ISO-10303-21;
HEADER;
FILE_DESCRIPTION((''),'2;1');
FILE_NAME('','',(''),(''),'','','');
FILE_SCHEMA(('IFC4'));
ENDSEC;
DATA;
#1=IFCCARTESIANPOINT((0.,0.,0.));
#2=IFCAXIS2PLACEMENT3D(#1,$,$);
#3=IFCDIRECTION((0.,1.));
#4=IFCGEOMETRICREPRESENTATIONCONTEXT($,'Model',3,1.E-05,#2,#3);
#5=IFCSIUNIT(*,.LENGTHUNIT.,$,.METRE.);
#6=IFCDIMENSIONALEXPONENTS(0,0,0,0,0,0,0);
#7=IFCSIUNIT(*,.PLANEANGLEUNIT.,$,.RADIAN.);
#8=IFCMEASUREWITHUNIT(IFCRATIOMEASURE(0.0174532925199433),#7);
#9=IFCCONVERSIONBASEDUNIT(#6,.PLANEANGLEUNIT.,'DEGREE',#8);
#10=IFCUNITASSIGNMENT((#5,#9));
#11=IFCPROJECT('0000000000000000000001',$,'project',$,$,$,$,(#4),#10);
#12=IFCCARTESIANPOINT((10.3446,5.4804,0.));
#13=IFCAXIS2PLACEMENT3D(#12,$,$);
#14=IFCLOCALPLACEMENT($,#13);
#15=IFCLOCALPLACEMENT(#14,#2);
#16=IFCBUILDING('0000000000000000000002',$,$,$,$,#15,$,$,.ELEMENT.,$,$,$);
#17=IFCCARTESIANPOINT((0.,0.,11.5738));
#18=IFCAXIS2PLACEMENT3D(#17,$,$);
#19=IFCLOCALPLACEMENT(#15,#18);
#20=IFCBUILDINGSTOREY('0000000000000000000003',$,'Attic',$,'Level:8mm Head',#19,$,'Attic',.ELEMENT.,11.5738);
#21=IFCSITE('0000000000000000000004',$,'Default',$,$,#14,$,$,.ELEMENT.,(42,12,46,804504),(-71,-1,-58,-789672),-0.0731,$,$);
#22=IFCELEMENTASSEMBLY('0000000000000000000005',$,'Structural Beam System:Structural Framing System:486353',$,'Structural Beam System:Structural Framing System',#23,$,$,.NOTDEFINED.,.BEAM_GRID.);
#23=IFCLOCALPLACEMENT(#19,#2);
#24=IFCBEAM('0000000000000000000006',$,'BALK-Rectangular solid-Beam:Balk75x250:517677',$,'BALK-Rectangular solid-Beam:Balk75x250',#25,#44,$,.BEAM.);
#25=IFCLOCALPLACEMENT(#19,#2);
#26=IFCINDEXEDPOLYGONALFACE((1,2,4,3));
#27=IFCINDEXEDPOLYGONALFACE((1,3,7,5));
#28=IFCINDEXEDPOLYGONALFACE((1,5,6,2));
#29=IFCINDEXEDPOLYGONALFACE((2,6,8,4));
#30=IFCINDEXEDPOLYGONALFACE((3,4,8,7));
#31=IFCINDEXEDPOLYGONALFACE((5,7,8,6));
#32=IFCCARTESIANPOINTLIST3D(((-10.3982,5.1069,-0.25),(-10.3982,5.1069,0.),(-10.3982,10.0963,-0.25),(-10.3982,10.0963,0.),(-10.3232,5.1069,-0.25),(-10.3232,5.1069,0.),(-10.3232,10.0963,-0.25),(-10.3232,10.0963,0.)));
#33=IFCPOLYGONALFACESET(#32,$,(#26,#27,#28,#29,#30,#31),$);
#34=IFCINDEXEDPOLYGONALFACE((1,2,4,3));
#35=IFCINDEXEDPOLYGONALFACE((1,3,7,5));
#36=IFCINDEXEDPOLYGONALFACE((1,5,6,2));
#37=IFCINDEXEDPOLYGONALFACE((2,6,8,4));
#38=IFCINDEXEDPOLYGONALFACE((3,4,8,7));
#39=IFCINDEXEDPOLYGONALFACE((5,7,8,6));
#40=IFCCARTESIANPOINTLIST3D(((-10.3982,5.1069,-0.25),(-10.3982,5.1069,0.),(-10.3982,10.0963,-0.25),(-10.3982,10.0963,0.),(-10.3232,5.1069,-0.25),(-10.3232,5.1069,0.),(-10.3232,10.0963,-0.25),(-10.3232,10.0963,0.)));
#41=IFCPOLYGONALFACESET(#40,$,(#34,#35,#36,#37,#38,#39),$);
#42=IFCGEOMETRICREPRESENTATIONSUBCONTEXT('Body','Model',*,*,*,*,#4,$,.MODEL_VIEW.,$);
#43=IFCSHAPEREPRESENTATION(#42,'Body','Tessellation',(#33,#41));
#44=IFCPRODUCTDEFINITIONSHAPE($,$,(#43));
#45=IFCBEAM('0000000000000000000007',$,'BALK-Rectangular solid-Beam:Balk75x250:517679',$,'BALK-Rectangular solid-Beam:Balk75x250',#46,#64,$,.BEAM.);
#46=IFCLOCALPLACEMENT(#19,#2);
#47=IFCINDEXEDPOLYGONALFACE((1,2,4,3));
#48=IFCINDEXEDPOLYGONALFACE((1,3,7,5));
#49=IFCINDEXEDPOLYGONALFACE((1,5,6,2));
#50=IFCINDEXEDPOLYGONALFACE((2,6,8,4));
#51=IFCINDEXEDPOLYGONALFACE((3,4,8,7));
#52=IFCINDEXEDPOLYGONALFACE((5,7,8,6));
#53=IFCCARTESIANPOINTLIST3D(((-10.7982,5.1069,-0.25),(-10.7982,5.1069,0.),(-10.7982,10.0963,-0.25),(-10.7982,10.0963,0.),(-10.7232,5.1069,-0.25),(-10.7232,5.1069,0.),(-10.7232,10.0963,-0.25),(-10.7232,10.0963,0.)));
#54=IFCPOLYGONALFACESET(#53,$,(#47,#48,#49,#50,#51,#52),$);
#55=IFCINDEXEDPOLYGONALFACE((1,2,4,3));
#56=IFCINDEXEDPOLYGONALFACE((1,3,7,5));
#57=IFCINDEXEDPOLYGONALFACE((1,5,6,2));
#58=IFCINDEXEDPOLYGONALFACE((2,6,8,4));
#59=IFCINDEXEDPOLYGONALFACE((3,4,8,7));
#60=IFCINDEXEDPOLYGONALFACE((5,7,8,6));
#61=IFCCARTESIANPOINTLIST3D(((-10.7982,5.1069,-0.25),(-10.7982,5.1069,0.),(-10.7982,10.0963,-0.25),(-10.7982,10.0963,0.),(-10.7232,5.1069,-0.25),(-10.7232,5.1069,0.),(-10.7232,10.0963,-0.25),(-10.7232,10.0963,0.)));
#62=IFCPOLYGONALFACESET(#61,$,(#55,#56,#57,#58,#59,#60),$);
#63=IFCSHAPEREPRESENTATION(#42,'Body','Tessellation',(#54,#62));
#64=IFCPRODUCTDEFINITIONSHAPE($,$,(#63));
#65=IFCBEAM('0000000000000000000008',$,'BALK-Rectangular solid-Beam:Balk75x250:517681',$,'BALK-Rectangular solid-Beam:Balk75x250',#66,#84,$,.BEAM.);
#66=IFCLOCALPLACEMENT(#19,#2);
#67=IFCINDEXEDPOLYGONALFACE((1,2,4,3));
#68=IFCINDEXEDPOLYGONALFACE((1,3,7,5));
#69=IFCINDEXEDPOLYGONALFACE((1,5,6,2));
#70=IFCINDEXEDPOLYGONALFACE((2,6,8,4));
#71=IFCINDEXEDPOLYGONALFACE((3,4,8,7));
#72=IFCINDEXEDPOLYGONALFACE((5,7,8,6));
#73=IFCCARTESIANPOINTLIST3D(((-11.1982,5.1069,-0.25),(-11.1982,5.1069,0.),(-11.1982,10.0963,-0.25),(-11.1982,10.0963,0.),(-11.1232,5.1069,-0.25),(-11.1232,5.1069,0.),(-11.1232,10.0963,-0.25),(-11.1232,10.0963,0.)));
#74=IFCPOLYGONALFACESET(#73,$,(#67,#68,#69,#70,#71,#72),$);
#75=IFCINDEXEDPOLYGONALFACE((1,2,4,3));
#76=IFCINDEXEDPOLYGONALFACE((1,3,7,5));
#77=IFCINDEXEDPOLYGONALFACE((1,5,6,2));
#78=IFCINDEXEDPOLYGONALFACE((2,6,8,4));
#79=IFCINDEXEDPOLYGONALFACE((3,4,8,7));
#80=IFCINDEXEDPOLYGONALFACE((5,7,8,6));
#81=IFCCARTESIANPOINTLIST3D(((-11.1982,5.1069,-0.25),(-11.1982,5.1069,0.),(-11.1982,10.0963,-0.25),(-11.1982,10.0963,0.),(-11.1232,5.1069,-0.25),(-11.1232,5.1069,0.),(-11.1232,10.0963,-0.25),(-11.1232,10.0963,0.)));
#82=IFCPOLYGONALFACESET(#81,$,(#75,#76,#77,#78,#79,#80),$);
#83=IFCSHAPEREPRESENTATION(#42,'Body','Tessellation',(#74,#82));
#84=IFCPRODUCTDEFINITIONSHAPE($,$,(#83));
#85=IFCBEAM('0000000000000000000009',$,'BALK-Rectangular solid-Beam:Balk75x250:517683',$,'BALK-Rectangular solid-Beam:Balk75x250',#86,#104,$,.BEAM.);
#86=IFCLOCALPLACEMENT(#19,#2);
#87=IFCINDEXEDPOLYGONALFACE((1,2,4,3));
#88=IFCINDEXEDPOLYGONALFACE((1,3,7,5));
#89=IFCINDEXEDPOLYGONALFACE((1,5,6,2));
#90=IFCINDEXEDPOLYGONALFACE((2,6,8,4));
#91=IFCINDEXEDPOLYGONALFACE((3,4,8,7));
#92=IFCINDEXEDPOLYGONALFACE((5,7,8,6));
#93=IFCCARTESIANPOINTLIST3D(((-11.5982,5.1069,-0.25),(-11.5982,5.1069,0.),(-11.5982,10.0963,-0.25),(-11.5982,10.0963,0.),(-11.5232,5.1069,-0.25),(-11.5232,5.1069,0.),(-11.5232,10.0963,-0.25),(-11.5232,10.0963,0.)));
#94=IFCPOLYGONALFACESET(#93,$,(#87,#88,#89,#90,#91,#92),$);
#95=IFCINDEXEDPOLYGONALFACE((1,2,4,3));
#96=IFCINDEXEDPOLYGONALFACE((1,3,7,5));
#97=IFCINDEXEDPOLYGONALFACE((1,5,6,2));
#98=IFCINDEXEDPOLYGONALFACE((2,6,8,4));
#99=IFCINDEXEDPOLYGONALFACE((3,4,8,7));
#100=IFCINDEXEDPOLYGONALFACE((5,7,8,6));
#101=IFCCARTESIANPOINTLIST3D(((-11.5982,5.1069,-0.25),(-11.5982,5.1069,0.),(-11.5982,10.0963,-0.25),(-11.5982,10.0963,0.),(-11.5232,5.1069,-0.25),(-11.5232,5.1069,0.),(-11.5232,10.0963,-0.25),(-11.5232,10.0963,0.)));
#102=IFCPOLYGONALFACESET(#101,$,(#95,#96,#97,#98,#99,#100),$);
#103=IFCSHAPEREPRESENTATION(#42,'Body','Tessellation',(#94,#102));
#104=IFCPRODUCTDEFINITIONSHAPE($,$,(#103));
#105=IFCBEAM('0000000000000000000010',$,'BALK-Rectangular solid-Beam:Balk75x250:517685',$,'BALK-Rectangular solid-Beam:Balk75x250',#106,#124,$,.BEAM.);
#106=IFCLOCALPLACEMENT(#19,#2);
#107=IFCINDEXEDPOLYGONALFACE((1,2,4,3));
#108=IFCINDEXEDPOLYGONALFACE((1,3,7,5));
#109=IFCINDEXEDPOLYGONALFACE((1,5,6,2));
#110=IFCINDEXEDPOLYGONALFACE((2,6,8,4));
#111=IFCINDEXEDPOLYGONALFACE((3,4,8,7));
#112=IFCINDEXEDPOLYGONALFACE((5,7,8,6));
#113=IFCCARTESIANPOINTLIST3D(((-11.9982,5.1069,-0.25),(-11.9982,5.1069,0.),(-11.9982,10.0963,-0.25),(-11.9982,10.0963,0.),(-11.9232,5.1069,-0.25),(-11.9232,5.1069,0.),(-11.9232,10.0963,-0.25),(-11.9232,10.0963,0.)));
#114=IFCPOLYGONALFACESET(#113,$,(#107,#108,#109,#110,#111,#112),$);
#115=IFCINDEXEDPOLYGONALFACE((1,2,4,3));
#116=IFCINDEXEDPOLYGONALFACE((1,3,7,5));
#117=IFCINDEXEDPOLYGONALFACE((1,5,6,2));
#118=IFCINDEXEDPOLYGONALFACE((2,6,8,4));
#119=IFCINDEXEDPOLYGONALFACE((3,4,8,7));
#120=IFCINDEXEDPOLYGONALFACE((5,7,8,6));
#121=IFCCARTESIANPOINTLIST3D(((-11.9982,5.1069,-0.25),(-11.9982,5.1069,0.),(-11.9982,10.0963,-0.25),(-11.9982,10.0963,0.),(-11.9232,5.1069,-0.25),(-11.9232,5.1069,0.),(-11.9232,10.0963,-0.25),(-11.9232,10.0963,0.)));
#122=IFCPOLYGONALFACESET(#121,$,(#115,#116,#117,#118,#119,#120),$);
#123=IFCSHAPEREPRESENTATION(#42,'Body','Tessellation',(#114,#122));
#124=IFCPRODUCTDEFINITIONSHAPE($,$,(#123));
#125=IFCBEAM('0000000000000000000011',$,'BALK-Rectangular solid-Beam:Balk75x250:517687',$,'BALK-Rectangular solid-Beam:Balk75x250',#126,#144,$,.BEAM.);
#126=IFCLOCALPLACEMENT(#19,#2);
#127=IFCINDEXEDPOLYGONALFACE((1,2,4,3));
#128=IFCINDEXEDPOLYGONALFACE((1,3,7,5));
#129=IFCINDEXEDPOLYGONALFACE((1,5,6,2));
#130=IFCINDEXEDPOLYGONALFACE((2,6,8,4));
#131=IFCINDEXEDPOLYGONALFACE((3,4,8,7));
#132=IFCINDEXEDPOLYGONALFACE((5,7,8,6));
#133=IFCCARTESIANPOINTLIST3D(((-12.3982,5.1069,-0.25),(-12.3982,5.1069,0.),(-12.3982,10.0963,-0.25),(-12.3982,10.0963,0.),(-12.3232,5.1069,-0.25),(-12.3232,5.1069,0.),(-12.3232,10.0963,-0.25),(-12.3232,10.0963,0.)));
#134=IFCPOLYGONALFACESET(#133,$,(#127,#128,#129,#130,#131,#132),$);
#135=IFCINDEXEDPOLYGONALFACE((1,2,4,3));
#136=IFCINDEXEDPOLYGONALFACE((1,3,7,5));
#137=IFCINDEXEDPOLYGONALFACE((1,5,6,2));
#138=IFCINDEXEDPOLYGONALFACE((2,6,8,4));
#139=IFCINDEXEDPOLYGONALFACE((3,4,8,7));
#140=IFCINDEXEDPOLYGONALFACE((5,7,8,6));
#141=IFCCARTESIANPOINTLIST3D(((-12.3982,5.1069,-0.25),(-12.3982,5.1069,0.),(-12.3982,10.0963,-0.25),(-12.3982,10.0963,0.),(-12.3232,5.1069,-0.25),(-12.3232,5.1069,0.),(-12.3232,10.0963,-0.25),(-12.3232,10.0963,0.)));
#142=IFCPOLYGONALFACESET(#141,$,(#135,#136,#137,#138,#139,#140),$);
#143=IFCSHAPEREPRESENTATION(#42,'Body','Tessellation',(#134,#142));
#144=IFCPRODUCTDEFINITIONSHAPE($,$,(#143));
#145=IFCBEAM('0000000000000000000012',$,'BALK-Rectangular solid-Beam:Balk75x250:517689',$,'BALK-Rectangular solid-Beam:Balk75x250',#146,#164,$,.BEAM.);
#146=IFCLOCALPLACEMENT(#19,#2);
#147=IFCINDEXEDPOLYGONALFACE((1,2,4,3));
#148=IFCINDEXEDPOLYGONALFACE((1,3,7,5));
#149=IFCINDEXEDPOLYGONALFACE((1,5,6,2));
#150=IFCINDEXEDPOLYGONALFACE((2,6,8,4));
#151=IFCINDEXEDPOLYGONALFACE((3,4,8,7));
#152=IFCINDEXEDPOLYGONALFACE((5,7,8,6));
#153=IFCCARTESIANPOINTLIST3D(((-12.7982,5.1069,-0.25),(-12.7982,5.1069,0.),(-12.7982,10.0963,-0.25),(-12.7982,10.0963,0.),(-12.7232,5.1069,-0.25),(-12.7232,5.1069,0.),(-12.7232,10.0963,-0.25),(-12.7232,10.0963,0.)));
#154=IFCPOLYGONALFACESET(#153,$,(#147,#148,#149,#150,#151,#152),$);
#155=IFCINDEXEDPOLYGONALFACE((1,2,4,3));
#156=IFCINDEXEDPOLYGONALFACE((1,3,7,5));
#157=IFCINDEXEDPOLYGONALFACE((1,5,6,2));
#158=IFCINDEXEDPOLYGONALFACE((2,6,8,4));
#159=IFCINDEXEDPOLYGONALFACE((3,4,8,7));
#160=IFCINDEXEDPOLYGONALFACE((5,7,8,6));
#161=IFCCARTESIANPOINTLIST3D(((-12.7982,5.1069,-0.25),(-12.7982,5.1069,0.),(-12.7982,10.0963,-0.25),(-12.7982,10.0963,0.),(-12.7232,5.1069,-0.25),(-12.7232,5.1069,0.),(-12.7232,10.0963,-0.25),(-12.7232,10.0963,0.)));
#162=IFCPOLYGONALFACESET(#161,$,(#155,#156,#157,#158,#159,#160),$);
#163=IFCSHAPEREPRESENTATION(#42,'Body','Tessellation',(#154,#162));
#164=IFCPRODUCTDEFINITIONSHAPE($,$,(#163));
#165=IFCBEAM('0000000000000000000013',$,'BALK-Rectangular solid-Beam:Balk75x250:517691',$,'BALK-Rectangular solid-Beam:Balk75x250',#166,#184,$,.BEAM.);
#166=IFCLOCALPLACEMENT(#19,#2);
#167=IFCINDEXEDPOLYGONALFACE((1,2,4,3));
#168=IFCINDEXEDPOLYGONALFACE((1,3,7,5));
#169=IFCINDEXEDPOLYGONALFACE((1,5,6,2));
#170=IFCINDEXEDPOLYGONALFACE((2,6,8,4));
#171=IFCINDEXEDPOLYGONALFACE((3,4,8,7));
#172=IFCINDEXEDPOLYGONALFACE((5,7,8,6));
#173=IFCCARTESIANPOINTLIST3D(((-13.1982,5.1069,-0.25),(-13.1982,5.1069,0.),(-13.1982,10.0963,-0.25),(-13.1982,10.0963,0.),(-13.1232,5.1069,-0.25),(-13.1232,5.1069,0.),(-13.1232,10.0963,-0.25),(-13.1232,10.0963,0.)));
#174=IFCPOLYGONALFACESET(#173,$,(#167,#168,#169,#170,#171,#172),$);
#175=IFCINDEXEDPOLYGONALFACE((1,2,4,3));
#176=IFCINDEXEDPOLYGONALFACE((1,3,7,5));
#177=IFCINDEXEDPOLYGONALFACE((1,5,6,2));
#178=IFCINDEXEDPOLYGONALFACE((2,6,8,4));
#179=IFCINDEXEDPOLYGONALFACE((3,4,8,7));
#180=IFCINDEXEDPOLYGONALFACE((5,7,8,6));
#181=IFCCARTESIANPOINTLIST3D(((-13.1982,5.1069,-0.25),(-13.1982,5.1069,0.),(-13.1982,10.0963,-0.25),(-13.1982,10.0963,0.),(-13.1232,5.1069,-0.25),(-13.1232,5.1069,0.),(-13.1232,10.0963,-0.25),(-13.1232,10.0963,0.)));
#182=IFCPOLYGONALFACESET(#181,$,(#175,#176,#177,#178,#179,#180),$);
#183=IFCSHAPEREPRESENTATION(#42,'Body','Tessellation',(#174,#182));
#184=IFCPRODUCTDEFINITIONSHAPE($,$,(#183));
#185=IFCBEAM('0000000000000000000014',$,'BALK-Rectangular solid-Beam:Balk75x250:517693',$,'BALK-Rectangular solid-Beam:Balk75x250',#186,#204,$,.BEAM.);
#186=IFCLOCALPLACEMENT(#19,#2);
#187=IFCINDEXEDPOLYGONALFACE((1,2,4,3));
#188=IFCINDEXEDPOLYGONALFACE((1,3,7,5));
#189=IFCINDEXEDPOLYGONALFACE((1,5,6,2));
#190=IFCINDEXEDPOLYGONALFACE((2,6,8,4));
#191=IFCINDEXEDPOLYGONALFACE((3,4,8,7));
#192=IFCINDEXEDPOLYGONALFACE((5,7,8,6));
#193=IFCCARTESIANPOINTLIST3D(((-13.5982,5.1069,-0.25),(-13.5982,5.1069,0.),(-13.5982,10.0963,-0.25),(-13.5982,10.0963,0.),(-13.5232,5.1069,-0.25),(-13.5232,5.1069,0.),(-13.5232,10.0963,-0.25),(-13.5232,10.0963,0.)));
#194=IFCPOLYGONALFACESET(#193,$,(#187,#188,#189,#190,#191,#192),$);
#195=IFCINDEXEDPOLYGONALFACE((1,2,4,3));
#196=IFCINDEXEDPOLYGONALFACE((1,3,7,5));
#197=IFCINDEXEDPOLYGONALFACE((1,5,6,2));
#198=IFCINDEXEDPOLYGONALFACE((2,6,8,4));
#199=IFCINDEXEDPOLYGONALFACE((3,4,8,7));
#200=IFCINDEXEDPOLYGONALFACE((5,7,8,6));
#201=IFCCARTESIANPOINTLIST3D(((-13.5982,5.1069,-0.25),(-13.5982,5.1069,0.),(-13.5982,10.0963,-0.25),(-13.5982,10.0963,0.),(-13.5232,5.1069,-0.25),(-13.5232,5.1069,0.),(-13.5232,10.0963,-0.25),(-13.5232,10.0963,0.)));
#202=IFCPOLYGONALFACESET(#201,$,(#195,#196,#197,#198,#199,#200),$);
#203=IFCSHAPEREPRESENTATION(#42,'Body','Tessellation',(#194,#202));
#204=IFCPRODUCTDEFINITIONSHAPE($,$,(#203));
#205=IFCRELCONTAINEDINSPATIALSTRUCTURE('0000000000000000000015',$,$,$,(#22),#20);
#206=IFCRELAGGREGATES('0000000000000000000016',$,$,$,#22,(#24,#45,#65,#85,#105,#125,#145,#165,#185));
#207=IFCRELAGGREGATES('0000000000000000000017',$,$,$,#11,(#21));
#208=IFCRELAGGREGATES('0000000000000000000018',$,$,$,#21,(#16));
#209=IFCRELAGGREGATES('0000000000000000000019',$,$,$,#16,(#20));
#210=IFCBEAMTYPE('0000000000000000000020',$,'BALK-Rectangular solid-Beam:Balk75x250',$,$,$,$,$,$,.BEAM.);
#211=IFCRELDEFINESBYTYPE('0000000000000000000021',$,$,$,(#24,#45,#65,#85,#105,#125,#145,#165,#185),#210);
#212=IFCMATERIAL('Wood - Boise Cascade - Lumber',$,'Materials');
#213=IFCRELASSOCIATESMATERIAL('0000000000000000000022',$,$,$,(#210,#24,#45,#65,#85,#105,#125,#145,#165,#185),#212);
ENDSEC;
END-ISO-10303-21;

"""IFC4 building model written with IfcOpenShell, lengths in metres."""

from ifc_helpers import new_model, entity, si_unit, converted_unit, direction, frame, frame_2d, origin, origin_2d_with_axis, place, context, subcontext, project, spatial, rectangle, extrude, source, transform, mapped, material, material_profile, profile_set, profile_usage, type_object, type_shapes, element, aggregate, save


model = new_model("IFC4")

# Units and contexts
model_context = context("Model", 3, precision=1e-05, world=origin(), true_north=direction((0.0, 1.0)))
body_context = subcontext(model_context, "Body", "Model", "MODEL_VIEW")
ifc_project = project(units=[si_unit("LENGTHUNIT", "METRE"), converted_unit("PLANEANGLEUNIT", "DEGREE", entity("IfcRatioMeasure", 0.0174532925199433), si_unit("PLANEANGLEUNIT", "RADIAN"), dimensions=[0, 0, 0, 0, 0, 0, 0])], contexts=[model_context])

# Site, building, storey
site_placement = place(None, frame((10.3446, 5.4804, 0.0)))
site = spatial("IfcSite", under=ifc_project, at=site_placement, Name="Default", CompositionType="ELEMENT", RefLatitude=(42, 12, 46, 804504), RefLongitude=(-71, -1, -58, -789672), RefElevation=-0.0731)
building_placement = place(site_placement, origin())
building = spatial("IfcBuilding", under=site, at=building_placement, CompositionType="ELEMENT")
storey_placement = place(building_placement, frame((0.0, 0.0, 11.5738)))
storey = spatial("IfcBuildingStorey", under=building, at=storey_placement, Name="Attic", ObjectType="Level:8mm Head", LongName="Attic", CompositionType="ELEMENT", Elevation=11.5738)

# Element assembly, beams
assembly_1_placement = place(storey_placement, origin())
assembly_1 = element("IfcElementAssembly", 1, at=assembly_1_placement, inside=storey, Name="Structural Beam System:Structural Framing System:486353", ObjectType="Structural Beam System:Structural Framing System", AssemblyPlace="NOTDEFINED", PredefinedType="BEAM_GRID")
ifc_material = material(Name="Wood - Boise Cascade - Lumber", Category="Materials")
ifc_material_profile = material_profile(ifc_material, rectangle(XDim=0.25, YDim=0.075, at=frame_2d((0.0, 0.0), x_axis=(1.0, 0.0))), Name="Balk75x250")
ifc_profile_set = profile_set([ifc_material_profile], Name="Balk75x250")
ifc_profile_usage_1 = profile_usage(ifc_profile_set, cardinal=8)
beam_type_1 = type_object("IfcBeamType", Name="BALK-Rectangular solid-Beam:Balk75x250", PredefinedType="BEAM", material=ifc_profile_set)
shared_shape_1 = source(origin(), body_context, "Body", "SweptSolid", [
    extrude(rectangle(XDim=0.25, YDim=0.075, at=origin_2d_with_axis()), frame((-2.4947, 0.0, 0.0), z_axis=(1.0, 0.0, 0.0), x_axis=(0.0, 0.0, -1.0)), (0.0, 0.0, 1.0), 4.9894),
    extrude(rectangle(XDim=0.25, YDim=0.075, at=origin_2d_with_axis()), frame((-2.4947, 0.0, 0.0), z_axis=(1.0, 0.0, 0.0), x_axis=(0.0, 0.0, -1.0)), (0.0, 0.0, 1.0), 4.9894),
])
type_shapes(beam_type_1, [shared_shape_1])
beam_1_placement = place(assembly_1_placement, frame((-10.3607, 7.6016, -0.125), z_axis=(0.0, 0.0, 1.0), x_axis=(0.0, -1.0, 0.0)))
beam_1 = element("IfcBeam", 2, at=beam_1_placement, type_object=beam_type_1, material=ifc_profile_usage_1, Name="BALK-Rectangular solid-Beam:Balk75x250:517677", ObjectType="BALK-Rectangular solid-Beam:Balk75x250", PredefinedType="BEAM", context=body_context, shape_type="MappedRepresentation", body=[
    mapped(shared_shape_1, transform((0.0, 0.0, 0.0), scale=1.0)),
])
ifc_profile_usage_2 = profile_usage(ifc_profile_set, cardinal=8)
beam_2_placement = place(assembly_1_placement, frame((-10.7607, 7.6016, -0.125), z_axis=(0.0, 0.0, 1.0), x_axis=(0.0, -1.0, 0.0)))
beam_2 = element("IfcBeam", 3, at=beam_2_placement, type_object=beam_type_1, material=ifc_profile_usage_2, Name="BALK-Rectangular solid-Beam:Balk75x250:517679", ObjectType="BALK-Rectangular solid-Beam:Balk75x250", PredefinedType="BEAM", context=body_context, shape_type="MappedRepresentation", body=[
    mapped(shared_shape_1, transform((0.0, 0.0, 0.0), scale=1.0)),
])
ifc_profile_usage_3 = profile_usage(ifc_profile_set, cardinal=8)
beam_3_placement = place(assembly_1_placement, frame((-11.1607, 7.6016, -0.125), z_axis=(0.0, 0.0, 1.0), x_axis=(0.0, -1.0, 0.0)))
beam_3 = element("IfcBeam", 4, at=beam_3_placement, type_object=beam_type_1, material=ifc_profile_usage_3, Name="BALK-Rectangular solid-Beam:Balk75x250:517681", ObjectType="BALK-Rectangular solid-Beam:Balk75x250", PredefinedType="BEAM", context=body_context, shape_type="MappedRepresentation", body=[
    mapped(shared_shape_1, transform((0.0, 0.0, 0.0), scale=1.0)),
])
ifc_profile_usage_4 = profile_usage(ifc_profile_set, cardinal=8)
beam_4_placement = place(assembly_1_placement, frame((-11.5607, 7.6016, -0.125), z_axis=(0.0, 0.0, 1.0), x_axis=(0.0, -1.0, 0.0)))
beam_4 = element("IfcBeam", 5, at=beam_4_placement, type_object=beam_type_1, material=ifc_profile_usage_4, Name="BALK-Rectangular solid-Beam:Balk75x250:517683", ObjectType="BALK-Rectangular solid-Beam:Balk75x250", PredefinedType="BEAM", context=body_context, shape_type="MappedRepresentation", body=[
    mapped(shared_shape_1, transform((0.0, 0.0, 0.0), scale=1.0)),
])
ifc_profile_usage_5 = profile_usage(ifc_profile_set, cardinal=8)
beam_5_placement = place(assembly_1_placement, frame((-11.9607, 7.6016, -0.125), z_axis=(0.0, 0.0, 1.0), x_axis=(0.0, -1.0, 0.0)))
beam_5 = element("IfcBeam", 6, at=beam_5_placement, type_object=beam_type_1, material=ifc_profile_usage_5, Name="BALK-Rectangular solid-Beam:Balk75x250:517685", ObjectType="BALK-Rectangular solid-Beam:Balk75x250", PredefinedType="BEAM", context=body_context, shape_type="MappedRepresentation", body=[
    mapped(shared_shape_1, transform((0.0, 0.0, 0.0), scale=1.0)),
])
ifc_profile_usage_6 = profile_usage(ifc_profile_set, cardinal=8)
beam_6_placement = place(assembly_1_placement, frame((-12.3607, 7.6016, -0.125), z_axis=(0.0, 0.0, 1.0), x_axis=(0.0, -1.0, 0.0)))
beam_6 = element("IfcBeam", 7, at=beam_6_placement, type_object=beam_type_1, material=ifc_profile_usage_6, Name="BALK-Rectangular solid-Beam:Balk75x250:517687", ObjectType="BALK-Rectangular solid-Beam:Balk75x250", PredefinedType="BEAM", context=body_context, shape_type="MappedRepresentation", body=[
    mapped(shared_shape_1, transform((0.0, 0.0, 0.0), scale=1.0)),
])
ifc_profile_usage_7 = profile_usage(ifc_profile_set, cardinal=8)
beam_7_placement = place(assembly_1_placement, frame((-12.7607, 7.6016, -0.125), z_axis=(0.0, 0.0, 1.0), x_axis=(0.0, -1.0, 0.0)))
beam_7 = element("IfcBeam", 8, at=beam_7_placement, type_object=beam_type_1, material=ifc_profile_usage_7, Name="BALK-Rectangular solid-Beam:Balk75x250:517689", ObjectType="BALK-Rectangular solid-Beam:Balk75x250", PredefinedType="BEAM", context=body_context, shape_type="MappedRepresentation", body=[
    mapped(shared_shape_1, transform((0.0, 0.0, 0.0), scale=1.0)),
])
ifc_profile_usage_8 = profile_usage(ifc_profile_set, cardinal=8)
beam_8_placement = place(assembly_1_placement, frame((-13.1607, 7.6016, -0.125), z_axis=(0.0, 0.0, 1.0), x_axis=(0.0, -1.0, 0.0)))
beam_8 = element("IfcBeam", 9, at=beam_8_placement, type_object=beam_type_1, material=ifc_profile_usage_8, Name="BALK-Rectangular solid-Beam:Balk75x250:517691", ObjectType="BALK-Rectangular solid-Beam:Balk75x250", PredefinedType="BEAM", context=body_context, shape_type="MappedRepresentation", body=[
    mapped(shared_shape_1, transform((0.0, 0.0, 0.0), scale=1.0)),
])
ifc_profile_usage_9 = profile_usage(ifc_profile_set, cardinal=8)
beam_9_placement = place(assembly_1_placement, frame((-13.5607, 7.6016, -0.125), z_axis=(0.0, 0.0, 1.0), x_axis=(0.0, -1.0, 0.0)))
beam_9 = element("IfcBeam", 10, at=beam_9_placement, type_object=beam_type_1, material=ifc_profile_usage_9, Name="BALK-Rectangular solid-Beam:Balk75x250:517693", ObjectType="BALK-Rectangular solid-Beam:Balk75x250", PredefinedType="BEAM", context=body_context, shape_type="MappedRepresentation", body=[
    mapped(shared_shape_1, transform((0.0, 0.0, 0.0), scale=1.0)),
])

aggregate(assembly_1, [beam_1, beam_2, beam_3, beam_4, beam_5, beam_6, beam_7, beam_8, beam_9])

save(model, "model.ifc")
